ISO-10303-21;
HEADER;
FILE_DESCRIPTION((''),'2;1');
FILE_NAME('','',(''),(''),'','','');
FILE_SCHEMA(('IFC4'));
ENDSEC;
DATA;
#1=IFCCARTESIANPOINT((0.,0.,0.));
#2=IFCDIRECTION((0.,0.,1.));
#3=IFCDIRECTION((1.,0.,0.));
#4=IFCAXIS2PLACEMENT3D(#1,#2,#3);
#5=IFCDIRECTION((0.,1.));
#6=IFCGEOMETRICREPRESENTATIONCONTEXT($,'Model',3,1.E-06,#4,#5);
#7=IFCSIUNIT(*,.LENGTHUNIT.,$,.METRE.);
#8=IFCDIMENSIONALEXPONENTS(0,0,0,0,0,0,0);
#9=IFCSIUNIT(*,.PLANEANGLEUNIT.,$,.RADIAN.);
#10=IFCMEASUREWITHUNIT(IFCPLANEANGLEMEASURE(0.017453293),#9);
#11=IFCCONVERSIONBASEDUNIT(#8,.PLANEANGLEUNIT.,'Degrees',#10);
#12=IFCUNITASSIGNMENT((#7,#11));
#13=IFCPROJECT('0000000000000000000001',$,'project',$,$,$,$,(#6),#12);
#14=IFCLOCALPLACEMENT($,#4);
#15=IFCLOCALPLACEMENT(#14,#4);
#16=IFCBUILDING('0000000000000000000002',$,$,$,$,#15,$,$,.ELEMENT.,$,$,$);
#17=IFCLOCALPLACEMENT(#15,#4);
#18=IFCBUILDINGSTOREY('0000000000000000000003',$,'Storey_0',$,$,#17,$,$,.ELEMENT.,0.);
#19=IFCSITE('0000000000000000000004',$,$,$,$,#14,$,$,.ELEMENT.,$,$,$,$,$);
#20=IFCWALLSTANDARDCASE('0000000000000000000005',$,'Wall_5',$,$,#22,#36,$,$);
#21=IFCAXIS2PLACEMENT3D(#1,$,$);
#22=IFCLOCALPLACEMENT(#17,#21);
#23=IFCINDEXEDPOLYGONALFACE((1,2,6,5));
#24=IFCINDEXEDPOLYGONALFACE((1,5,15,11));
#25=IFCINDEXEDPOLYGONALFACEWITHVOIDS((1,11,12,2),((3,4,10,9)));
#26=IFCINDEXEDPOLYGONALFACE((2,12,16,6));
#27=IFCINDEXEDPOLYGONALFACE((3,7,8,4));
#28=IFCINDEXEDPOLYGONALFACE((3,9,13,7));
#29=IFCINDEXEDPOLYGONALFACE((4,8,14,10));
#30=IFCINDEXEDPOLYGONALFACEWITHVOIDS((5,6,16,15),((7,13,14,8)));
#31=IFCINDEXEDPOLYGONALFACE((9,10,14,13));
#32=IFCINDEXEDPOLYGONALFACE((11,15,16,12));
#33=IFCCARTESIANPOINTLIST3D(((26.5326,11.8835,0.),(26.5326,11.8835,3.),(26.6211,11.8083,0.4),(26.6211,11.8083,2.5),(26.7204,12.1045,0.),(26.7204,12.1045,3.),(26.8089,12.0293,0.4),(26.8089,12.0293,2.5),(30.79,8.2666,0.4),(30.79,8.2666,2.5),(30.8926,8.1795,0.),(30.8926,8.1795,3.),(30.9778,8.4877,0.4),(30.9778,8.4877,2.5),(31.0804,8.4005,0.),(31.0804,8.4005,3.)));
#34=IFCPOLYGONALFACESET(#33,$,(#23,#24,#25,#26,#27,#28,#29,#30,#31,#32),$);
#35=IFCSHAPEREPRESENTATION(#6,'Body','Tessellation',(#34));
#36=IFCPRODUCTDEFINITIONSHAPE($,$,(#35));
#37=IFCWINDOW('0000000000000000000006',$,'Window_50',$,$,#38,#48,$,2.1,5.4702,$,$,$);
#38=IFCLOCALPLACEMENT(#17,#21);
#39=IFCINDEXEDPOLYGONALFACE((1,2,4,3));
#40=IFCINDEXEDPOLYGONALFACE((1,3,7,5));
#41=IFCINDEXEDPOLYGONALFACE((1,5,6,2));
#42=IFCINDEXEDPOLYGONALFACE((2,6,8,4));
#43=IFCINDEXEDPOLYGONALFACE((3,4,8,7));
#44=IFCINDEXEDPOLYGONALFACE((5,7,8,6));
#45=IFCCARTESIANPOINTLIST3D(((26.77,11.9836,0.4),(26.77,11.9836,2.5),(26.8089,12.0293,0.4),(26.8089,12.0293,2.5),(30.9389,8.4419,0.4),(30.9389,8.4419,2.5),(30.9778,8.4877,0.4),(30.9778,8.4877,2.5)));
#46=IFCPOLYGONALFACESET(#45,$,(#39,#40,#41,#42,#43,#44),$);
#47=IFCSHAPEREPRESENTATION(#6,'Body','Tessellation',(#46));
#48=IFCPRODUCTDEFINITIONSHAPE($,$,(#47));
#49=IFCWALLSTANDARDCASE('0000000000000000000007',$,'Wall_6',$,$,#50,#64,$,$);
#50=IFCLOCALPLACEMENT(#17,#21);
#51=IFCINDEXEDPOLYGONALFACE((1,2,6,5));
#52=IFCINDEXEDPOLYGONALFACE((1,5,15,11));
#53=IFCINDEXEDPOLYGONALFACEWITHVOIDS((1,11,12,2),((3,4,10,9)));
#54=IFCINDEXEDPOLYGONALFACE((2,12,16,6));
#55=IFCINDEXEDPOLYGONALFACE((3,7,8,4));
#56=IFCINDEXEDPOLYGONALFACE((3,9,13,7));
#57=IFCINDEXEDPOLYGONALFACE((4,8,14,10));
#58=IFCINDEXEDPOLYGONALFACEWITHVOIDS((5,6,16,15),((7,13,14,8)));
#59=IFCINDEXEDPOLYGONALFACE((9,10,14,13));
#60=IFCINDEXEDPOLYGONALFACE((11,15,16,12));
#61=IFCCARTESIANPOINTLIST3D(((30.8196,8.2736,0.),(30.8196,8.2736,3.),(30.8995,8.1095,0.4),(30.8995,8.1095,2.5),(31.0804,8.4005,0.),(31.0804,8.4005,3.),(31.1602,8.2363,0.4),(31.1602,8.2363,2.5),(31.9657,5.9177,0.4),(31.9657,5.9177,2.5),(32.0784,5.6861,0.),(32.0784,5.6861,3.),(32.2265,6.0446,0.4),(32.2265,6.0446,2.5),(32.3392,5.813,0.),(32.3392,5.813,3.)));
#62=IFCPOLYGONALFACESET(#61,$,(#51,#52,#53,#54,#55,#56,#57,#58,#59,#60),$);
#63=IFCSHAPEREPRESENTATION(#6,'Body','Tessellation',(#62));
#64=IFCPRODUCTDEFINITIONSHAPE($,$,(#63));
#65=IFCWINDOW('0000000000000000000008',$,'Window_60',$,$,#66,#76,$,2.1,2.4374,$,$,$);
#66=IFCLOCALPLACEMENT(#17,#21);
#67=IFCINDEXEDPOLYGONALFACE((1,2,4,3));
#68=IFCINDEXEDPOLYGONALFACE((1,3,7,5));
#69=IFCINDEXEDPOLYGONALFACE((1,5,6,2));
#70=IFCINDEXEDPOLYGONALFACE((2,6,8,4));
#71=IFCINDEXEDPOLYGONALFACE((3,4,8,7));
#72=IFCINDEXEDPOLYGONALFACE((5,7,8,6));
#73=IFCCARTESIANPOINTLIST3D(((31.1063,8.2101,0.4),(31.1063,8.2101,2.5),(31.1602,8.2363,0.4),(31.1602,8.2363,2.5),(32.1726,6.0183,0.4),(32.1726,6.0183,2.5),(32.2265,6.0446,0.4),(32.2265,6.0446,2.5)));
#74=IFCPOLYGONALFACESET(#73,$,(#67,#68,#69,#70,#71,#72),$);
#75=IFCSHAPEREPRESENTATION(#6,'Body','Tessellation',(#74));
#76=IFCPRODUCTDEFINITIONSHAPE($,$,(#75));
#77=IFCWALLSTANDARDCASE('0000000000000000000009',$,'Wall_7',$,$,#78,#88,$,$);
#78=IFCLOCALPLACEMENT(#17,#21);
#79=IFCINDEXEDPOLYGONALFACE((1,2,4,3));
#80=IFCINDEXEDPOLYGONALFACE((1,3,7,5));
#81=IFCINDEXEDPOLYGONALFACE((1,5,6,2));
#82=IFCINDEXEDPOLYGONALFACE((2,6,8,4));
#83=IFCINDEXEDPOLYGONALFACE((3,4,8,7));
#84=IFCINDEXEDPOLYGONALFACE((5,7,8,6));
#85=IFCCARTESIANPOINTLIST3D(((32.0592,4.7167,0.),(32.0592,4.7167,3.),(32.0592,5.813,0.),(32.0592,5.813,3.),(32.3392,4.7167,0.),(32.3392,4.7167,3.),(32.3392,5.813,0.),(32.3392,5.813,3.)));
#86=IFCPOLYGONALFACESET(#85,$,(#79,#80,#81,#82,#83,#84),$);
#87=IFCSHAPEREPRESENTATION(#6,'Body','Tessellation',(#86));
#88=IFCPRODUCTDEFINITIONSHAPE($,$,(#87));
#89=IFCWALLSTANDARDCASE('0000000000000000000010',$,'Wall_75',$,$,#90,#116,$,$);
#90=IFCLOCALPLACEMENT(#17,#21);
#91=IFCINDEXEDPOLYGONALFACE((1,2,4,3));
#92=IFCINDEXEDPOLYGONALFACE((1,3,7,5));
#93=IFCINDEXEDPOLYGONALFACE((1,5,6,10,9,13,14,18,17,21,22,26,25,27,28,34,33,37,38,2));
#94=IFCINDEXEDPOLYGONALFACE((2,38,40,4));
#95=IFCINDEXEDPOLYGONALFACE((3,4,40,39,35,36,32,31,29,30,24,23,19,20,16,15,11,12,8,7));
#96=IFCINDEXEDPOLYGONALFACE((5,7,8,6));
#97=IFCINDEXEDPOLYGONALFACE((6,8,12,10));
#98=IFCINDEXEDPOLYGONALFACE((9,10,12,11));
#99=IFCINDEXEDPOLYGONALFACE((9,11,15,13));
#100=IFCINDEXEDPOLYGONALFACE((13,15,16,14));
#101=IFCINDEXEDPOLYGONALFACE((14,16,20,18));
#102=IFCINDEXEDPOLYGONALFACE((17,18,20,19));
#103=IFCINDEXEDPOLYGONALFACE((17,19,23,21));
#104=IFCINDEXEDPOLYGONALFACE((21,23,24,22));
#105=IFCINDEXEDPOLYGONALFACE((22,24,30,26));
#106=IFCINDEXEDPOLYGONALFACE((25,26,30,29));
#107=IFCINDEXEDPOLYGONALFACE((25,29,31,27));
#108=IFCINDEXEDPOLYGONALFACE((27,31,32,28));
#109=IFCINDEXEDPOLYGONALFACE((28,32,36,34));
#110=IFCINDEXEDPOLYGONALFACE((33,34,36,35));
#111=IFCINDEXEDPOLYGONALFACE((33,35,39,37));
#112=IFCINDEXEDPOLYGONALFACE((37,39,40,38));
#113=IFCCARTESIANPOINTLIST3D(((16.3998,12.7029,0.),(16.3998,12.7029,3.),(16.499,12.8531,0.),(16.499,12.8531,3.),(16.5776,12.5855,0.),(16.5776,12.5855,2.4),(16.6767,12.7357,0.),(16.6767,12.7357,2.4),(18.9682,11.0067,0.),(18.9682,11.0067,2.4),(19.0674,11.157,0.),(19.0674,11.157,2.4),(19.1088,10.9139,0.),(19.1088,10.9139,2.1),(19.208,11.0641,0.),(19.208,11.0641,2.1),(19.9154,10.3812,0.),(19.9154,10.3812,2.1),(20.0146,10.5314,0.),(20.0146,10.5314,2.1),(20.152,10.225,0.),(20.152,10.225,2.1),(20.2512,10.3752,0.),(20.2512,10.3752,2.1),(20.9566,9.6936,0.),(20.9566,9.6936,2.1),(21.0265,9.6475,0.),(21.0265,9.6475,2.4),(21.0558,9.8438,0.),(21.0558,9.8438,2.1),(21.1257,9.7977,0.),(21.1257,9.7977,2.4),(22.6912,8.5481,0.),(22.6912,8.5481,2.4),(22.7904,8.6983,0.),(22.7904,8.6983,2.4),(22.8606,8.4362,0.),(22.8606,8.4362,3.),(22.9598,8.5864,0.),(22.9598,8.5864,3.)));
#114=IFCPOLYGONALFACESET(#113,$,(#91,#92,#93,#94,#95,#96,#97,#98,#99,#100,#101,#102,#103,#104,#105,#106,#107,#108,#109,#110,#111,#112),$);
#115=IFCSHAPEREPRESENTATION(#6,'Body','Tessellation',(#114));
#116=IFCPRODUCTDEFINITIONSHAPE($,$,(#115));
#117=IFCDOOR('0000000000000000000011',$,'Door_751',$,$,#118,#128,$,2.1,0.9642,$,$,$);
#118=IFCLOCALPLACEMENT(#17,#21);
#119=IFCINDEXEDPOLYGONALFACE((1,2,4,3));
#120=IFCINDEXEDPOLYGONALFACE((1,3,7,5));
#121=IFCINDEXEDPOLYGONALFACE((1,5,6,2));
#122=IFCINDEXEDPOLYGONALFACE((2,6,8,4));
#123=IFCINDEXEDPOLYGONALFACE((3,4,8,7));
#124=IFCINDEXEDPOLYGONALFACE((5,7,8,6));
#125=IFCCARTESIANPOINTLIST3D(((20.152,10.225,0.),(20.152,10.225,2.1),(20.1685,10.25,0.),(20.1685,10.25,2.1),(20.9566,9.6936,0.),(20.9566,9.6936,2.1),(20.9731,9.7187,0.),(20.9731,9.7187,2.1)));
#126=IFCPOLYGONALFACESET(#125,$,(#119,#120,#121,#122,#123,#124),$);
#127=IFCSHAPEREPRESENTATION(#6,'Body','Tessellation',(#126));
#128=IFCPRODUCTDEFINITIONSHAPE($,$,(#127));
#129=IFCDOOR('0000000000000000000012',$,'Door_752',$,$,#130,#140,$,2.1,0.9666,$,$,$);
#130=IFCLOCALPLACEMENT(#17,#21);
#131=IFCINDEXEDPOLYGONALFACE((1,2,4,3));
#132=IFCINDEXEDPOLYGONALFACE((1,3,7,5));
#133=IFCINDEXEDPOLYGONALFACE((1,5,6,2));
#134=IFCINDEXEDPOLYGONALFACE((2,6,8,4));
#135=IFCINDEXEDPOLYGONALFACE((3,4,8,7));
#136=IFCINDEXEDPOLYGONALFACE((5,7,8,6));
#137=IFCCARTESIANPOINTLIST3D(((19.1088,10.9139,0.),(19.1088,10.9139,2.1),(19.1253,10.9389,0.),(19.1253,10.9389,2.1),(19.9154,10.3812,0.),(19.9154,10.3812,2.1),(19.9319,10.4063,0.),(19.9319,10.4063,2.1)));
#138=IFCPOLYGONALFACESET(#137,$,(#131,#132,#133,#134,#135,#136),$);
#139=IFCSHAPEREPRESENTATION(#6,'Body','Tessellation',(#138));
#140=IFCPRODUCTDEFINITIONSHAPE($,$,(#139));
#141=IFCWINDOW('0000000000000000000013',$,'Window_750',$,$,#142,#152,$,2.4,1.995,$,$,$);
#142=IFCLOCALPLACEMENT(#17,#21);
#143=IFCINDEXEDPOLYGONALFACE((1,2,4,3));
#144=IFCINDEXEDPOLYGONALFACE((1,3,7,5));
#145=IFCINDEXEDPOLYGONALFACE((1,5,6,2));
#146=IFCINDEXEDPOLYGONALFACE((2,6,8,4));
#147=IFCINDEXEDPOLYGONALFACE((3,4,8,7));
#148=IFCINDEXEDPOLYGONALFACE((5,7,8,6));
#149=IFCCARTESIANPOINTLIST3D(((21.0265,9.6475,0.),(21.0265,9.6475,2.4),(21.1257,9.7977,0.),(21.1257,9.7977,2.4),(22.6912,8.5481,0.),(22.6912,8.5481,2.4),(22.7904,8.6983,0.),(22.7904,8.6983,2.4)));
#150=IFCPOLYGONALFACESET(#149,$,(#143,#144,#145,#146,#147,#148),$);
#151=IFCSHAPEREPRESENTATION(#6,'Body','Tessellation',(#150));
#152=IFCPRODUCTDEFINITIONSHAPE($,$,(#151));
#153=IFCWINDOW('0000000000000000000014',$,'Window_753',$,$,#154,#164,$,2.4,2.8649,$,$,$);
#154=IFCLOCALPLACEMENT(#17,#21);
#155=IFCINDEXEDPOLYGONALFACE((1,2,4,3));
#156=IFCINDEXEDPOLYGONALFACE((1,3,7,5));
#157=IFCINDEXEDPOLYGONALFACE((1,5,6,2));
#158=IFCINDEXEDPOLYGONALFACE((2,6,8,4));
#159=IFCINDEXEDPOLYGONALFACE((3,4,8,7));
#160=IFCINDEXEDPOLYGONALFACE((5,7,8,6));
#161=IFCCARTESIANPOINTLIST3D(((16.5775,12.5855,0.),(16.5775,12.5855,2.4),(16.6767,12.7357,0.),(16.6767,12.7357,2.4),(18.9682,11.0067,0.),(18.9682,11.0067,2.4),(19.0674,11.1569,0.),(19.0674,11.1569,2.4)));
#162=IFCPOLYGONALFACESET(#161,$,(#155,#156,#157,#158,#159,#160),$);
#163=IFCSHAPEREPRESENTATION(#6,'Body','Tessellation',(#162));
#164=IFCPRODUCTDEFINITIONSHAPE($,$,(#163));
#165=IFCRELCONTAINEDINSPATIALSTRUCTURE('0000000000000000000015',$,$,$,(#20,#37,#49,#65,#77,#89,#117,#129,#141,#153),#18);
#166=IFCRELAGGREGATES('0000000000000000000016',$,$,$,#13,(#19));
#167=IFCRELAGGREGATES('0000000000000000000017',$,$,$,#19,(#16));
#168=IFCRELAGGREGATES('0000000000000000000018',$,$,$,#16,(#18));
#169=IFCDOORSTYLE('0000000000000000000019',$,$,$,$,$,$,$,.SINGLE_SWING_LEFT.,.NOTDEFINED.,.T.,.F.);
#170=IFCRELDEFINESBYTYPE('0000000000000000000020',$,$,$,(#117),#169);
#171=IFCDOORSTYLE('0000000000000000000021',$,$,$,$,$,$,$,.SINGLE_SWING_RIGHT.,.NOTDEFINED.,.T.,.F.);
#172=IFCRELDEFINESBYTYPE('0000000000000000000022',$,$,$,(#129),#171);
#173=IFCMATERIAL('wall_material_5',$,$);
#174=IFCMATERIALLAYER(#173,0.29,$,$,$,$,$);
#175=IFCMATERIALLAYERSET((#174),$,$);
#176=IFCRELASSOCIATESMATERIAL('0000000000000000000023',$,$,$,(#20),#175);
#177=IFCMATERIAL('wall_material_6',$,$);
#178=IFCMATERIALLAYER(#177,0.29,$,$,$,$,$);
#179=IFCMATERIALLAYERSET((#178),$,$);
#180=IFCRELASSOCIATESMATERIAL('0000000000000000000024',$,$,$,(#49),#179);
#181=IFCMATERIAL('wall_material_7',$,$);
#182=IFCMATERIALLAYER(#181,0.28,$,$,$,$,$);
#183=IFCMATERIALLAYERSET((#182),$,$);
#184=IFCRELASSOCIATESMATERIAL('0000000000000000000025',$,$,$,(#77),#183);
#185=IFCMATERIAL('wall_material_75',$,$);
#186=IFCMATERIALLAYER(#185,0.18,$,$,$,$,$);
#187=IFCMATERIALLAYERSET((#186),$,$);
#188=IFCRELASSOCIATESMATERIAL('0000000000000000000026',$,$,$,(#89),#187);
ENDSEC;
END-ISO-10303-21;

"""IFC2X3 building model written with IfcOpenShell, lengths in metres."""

from ifc_helpers import new_model, entity, si_unit, converted_unit, direction, frame, frame_2d, origin_with_axes, place, context, project, spatial, polyline, rectangle, outline, extrude, material, layer, layer_set, layer_usage, type_object, element, fill, save


model = new_model("IFC2X3")

# Units and contexts
model_context = context("Model", 3, precision=1e-06, world=origin_with_axes(), true_north=direction((0.0, 1.0)))
ifc_project = project(units=[si_unit("LENGTHUNIT", "METRE"), converted_unit("PLANEANGLEUNIT", "Degrees", entity("IfcPlaneAngleMeasure", 0.017453293), si_unit("PLANEANGLEUNIT", "RADIAN"), dimensions=[0, 0, 0, 0, 0, 0, 0])], contexts=[model_context])

# Site, building, storey
site_placement = place(None, origin_with_axes())
site = spatial("IfcSite", under=ifc_project, at=site_placement, CompositionType="ELEMENT")
building_placement = place(site_placement, origin_with_axes())
building = spatial("IfcBuilding", under=site, at=building_placement, CompositionType="ELEMENT")
storey_placement = place(building_placement, origin_with_axes())
storey = spatial("IfcBuildingStorey", under=building, at=storey_placement, Name="Storey_0", CompositionType="ELEMENT", Elevation=0.0)

# Walls, openings, windows
ifc_material_1 = material(Name="wall_material_5")
ifc_layer_1 = layer(ifc_material_1, 0.29)
ifc_layer_set_1 = layer_set([ifc_layer_1])
ifc_layer_usage_1 = layer_usage(ifc_layer_set_1, "AXIS2", "NEGATIVE", 0.0)
wall_1_placement = place(storey_placement, frame((26.7204, 12.1045, 0.0), z_axis=(0.0, 0.0, 1.0), x_axis=(0.762111, -0.647446, 0.0)))
wall_1 = element("IfcWallStandardCase", 1, at=wall_1_placement, inside=storey, material=ifc_layer_usage_1, Name="Wall_5", context=model_context, shape_type="SweptSolid", body=[
    extrude(outline(polyline([(0.0, 0.0), (5.7209, 0.0), (5.7209, -0.29), (0.0, -0.29), (0.0, 0.0)])), origin_with_axes(), (0.0, 0.0, 1.0), 3.0),
])
opening_1_placement = place(wall_1_placement, frame((0.1161, 0.0, 0.4), z_axis=(0.0, 0.0, 1.0), x_axis=(1.0, 0.0, 0.0)))
opening_1 = element("IfcOpeningElement", 2, at=opening_1_placement, cuts=wall_1, context=model_context, shape_type="SweptSolid", body=[
    extrude(rectangle(XDim=5.4702, YDim=2.1, at=frame_2d((1.05, -2.7351), x_axis=(0.0, 1.0))), frame((0.0, 0.01, 0.0), z_axis=(0.0, -1.0, 0.0), x_axis=(0.0, 0.0, 1.0)), (0.0, 0.0, 1.0), 0.31),
])
window_1_placement = place(storey_placement, frame((0.0, 0.0, 0.4), z_axis=(0.0, 0.0, 1.0), x_axis=(1.0, 0.0, 0.0)))
window_1 = element("IfcWindow", 3, at=window_1_placement, inside=storey, Name="Window_50", OverallHeight=2.1, OverallWidth=5.4702, context=model_context, shape_type="SweptSolid", body=[
    extrude(outline(polyline([(26.8089, 12.0293), (30.9778, 8.4877), (30.9389, 8.4419), (26.77, 11.9836), (26.8089, 12.0293)])), origin_with_axes(), (0.0, 0.0, 1.0), 2.1),
])
fill(opening_1, window_1)
ifc_material_2 = material(Name="wall_material_6")
ifc_layer_2 = layer(ifc_material_2, 0.29)
ifc_layer_set_2 = layer_set([ifc_layer_2])
ifc_layer_usage_2 = layer_usage(ifc_layer_set_2, "AXIS2", "NEGATIVE", 0.0)
wall_2_placement = place(storey_placement, frame((31.0804, 8.4005, 0.0), z_axis=(0.0, 0.0, 1.0), x_axis=(0.437474, -0.899231, 0.0)))
wall_2 = element("IfcWallStandardCase", 4, at=wall_2_placement, inside=storey, material=ifc_layer_usage_2, Name="Wall_6", context=model_context, shape_type="SweptSolid", body=[
    extrude(outline(polyline([(0.0, 0.0), (2.8775, 0.0), (2.8775, -0.29), (0.0, -0.29), (0.0, 0.0)])), origin_with_axes(), (0.0, 0.0, 1.0), 3.0),
])
opening_2_placement = place(wall_2_placement, frame((0.1825, 0.0, 0.4), z_axis=(0.0, 0.0, 1.0), x_axis=(1.0, 0.0, 0.0)))
opening_2 = element("IfcOpeningElement", 5, at=opening_2_placement, cuts=wall_2, context=model_context, shape_type="SweptSolid", body=[
    extrude(rectangle(XDim=2.4374, YDim=2.1, at=frame_2d((1.05, -1.2187), x_axis=(0.0, 1.0))), frame((0.0, 0.01, 0.0), z_axis=(0.0, -1.0, 0.0), x_axis=(0.0, 0.0, 1.0)), (0.0, 0.0, 1.0), 0.31),
])
window_2_placement = place(storey_placement, frame((0.0, 0.0, 0.4), z_axis=(0.0, 0.0, 1.0), x_axis=(1.0, 0.0, 0.0)))
window_2 = element("IfcWindow", 6, at=window_2_placement, inside=storey, Name="Window_60", OverallHeight=2.1, OverallWidth=2.4374, context=model_context, shape_type="SweptSolid", body=[
    extrude(outline(polyline([(31.1602, 8.2363), (32.2265, 6.0446), (32.1726, 6.0183), (31.1063, 8.2101), (31.1602, 8.2363)])), origin_with_axes(), (0.0, 0.0, 1.0), 2.1),
])
fill(opening_2, window_2)

# Wall
ifc_material_3 = material(Name="wall_material_7")
ifc_layer_3 = layer(ifc_material_3, 0.28)
ifc_layer_set_3 = layer_set([ifc_layer_3])
ifc_layer_usage_3 = layer_usage(ifc_layer_set_3, "AXIS2", "NEGATIVE", 0.0)
wall_3_placement = place(storey_placement, frame((32.3392, 5.813, 0.0), z_axis=(0.0, 0.0, 1.0), x_axis=(0.0, -1.0, 0.0)))
element("IfcWallStandardCase", 7, at=wall_3_placement, inside=storey, material=ifc_layer_usage_3, Name="Wall_7", context=model_context, shape_type="SweptSolid", body=[
    extrude(outline(polyline([(0.0, 0.0), (1.0963, 0.0), (1.0963, -0.28), (0.0, -0.28), (0.0, 0.0)])), origin_with_axes(), (0.0, 0.0, 1.0), 3.0),
])

# Wall, openings, doors, windows
ifc_material_4 = material(Name="wall_material_75")
ifc_layer_4 = layer(ifc_material_4, 0.18)
ifc_layer_set_4 = layer_set([ifc_layer_4])
ifc_layer_usage_4 = layer_usage(ifc_layer_set_4, "AXIS2", "POSITIVE", 0.0)
wall_4_placement = place(storey_placement, frame((22.9598, 8.5864, 0.0), z_axis=(0.0, 0.0, 1.0), x_axis=(-0.834459, 0.55107, 0.0)))
wall_4 = element("IfcWallStandardCase", 8, at=wall_4_placement, inside=storey, material=ifc_layer_usage_4, Name="Wall_75", context=model_context, shape_type="SweptSolid", body=[
    extrude(outline(polyline([(0.0, 0.18), (7.7425, 0.18), (7.7425, 0.0), (0.0, 0.0), (0.0, 0.18)])), origin_with_axes(), (0.0, 0.0, 1.0), 3.0),
])
opening_3_placement = place(wall_4_placement, frame((0.203, 0.18, 0.0), z_axis=(0.0, 0.0, 1.0), x_axis=(1.0, 0.0, 0.0)))
opening_3 = element("IfcOpeningElement", 9, at=opening_3_placement, cuts=wall_4, context=model_context, shape_type="SweptSolid", body=[
    extrude(rectangle(XDim=1.995, YDim=2.4, at=frame_2d((1.2, -0.9975), x_axis=(0.0, 1.0))), frame((0.0, 0.01, 0.0), z_axis=(0.0, -1.0, 0.0), x_axis=(0.0, 0.0, 1.0)), (0.0, 0.0, 1.0), 0.2),
])
opening_4_placement = place(wall_4_placement, frame((2.2818, 0.18, 0.0), z_axis=(0.0, 0.0, 1.0), x_axis=(1.0, 0.0, 0.0)))
opening_4 = element("IfcOpeningElement", 10, at=opening_4_placement, cuts=wall_4, context=model_context, shape_type="SweptSolid", body=[
    extrude(rectangle(XDim=0.9642, YDim=2.1, at=frame_2d((1.05, -0.4821), x_axis=(0.0, 1.0))), frame((0.0, 0.01, 0.0), z_axis=(0.0, -1.0, 0.0), x_axis=(0.0, 0.0, 1.0)), (0.0, 0.0, 1.0), 0.2),
])
opening_5_placement = place(wall_4_placement, frame((3.5295, 0.18, 0.0), z_axis=(0.0, 0.0, 1.0), x_axis=(1.0, 0.0, 0.0)))
opening_5 = element("IfcOpeningElement", 11, at=opening_5_placement, cuts=wall_4, context=model_context, shape_type="SweptSolid", body=[
    extrude(rectangle(XDim=0.9666, YDim=2.1, at=frame_2d((1.05, -0.4833), x_axis=(0.0, 1.0))), frame((0.0, 0.01, 0.0), z_axis=(0.0, -1.0, 0.0), x_axis=(0.0, 0.0, 1.0)), (0.0, 0.0, 1.0), 0.2),
])
opening_6_placement = place(wall_4_placement, frame((4.6646, 0.18, 0.0), z_axis=(0.0, 0.0, 1.0), x_axis=(1.0, 0.0, 0.0)))
opening_6 = element("IfcOpeningElement", 12, at=opening_6_placement, cuts=wall_4, context=model_context, shape_type="SweptSolid", body=[
    extrude(rectangle(XDim=2.8649, YDim=2.4, at=frame_2d((1.2, -1.4325), x_axis=(0.0, 1.0))), frame((0.0, 0.01, 0.0), z_axis=(0.0, -1.0, 0.0), x_axis=(0.0, 0.0, 1.0)), (0.0, 0.0, 1.0), 0.2),
])
door_style_1 = type_object("IfcDoorStyle", ConstructionType="NOTDEFINED", OperationType="SINGLE_SWING_LEFT", ParameterTakesPrecedence=True, Sizeable=False)
door_1_placement = place(storey_placement, origin_with_axes())
door_1 = element("IfcDoor", 13, at=door_1_placement, inside=storey, type_object=door_style_1, Name="Door_751", OverallHeight=2.1, OverallWidth=0.9642, context=model_context, shape_type="SweptSolid", body=[
    extrude(outline(polyline([(20.9566, 9.6936), (20.152, 10.225), (20.1685, 10.25), (20.9731, 9.7187), (20.9566, 9.6936)])), origin_with_axes(), (0.0, 0.0, 1.0), 2.1),
])
fill(opening_4, door_1)
door_style_2 = type_object("IfcDoorStyle", ConstructionType="NOTDEFINED", OperationType="SINGLE_SWING_RIGHT", ParameterTakesPrecedence=True, Sizeable=False)
door_2_placement = place(storey_placement, origin_with_axes())
door_2 = element("IfcDoor", 14, at=door_2_placement, inside=storey, type_object=door_style_2, Name="Door_752", OverallHeight=2.1, OverallWidth=0.9666, context=model_context, shape_type="SweptSolid", body=[
    extrude(outline(polyline([(19.9154, 10.3812), (19.1088, 10.9139), (19.1253, 10.9389), (19.9319, 10.4063), (19.9154, 10.3812)])), origin_with_axes(), (0.0, 0.0, 1.0), 2.1),
])
fill(opening_5, door_2)
window_3_placement = place(storey_placement, origin_with_axes())
window_3 = element("IfcWindow", 15, at=window_3_placement, inside=storey, Name="Window_750", OverallHeight=2.4, OverallWidth=1.995, context=model_context, shape_type="SweptSolid", body=[
    extrude(outline(polyline([(22.6912, 8.5481), (21.0265, 9.6475), (21.1257, 9.7977), (22.7904, 8.6983), (22.6912, 8.5481)])), origin_with_axes(), (0.0, 0.0, 1.0), 2.4),
])
fill(opening_3, window_3)
window_4_placement = place(storey_placement, origin_with_axes())
window_4 = element("IfcWindow", 16, at=window_4_placement, inside=storey, Name="Window_753", OverallHeight=2.4, OverallWidth=2.8649, context=model_context, shape_type="SweptSolid", body=[
    extrude(outline(polyline([(18.9682, 11.0067), (16.5775, 12.5855), (16.6767, 12.7357), (19.0674, 11.1569), (18.9682, 11.0067)])), origin_with_axes(), (0.0, 0.0, 1.0), 2.4),
])
fill(opening_6, window_4)

save(model, "model.ifc")
